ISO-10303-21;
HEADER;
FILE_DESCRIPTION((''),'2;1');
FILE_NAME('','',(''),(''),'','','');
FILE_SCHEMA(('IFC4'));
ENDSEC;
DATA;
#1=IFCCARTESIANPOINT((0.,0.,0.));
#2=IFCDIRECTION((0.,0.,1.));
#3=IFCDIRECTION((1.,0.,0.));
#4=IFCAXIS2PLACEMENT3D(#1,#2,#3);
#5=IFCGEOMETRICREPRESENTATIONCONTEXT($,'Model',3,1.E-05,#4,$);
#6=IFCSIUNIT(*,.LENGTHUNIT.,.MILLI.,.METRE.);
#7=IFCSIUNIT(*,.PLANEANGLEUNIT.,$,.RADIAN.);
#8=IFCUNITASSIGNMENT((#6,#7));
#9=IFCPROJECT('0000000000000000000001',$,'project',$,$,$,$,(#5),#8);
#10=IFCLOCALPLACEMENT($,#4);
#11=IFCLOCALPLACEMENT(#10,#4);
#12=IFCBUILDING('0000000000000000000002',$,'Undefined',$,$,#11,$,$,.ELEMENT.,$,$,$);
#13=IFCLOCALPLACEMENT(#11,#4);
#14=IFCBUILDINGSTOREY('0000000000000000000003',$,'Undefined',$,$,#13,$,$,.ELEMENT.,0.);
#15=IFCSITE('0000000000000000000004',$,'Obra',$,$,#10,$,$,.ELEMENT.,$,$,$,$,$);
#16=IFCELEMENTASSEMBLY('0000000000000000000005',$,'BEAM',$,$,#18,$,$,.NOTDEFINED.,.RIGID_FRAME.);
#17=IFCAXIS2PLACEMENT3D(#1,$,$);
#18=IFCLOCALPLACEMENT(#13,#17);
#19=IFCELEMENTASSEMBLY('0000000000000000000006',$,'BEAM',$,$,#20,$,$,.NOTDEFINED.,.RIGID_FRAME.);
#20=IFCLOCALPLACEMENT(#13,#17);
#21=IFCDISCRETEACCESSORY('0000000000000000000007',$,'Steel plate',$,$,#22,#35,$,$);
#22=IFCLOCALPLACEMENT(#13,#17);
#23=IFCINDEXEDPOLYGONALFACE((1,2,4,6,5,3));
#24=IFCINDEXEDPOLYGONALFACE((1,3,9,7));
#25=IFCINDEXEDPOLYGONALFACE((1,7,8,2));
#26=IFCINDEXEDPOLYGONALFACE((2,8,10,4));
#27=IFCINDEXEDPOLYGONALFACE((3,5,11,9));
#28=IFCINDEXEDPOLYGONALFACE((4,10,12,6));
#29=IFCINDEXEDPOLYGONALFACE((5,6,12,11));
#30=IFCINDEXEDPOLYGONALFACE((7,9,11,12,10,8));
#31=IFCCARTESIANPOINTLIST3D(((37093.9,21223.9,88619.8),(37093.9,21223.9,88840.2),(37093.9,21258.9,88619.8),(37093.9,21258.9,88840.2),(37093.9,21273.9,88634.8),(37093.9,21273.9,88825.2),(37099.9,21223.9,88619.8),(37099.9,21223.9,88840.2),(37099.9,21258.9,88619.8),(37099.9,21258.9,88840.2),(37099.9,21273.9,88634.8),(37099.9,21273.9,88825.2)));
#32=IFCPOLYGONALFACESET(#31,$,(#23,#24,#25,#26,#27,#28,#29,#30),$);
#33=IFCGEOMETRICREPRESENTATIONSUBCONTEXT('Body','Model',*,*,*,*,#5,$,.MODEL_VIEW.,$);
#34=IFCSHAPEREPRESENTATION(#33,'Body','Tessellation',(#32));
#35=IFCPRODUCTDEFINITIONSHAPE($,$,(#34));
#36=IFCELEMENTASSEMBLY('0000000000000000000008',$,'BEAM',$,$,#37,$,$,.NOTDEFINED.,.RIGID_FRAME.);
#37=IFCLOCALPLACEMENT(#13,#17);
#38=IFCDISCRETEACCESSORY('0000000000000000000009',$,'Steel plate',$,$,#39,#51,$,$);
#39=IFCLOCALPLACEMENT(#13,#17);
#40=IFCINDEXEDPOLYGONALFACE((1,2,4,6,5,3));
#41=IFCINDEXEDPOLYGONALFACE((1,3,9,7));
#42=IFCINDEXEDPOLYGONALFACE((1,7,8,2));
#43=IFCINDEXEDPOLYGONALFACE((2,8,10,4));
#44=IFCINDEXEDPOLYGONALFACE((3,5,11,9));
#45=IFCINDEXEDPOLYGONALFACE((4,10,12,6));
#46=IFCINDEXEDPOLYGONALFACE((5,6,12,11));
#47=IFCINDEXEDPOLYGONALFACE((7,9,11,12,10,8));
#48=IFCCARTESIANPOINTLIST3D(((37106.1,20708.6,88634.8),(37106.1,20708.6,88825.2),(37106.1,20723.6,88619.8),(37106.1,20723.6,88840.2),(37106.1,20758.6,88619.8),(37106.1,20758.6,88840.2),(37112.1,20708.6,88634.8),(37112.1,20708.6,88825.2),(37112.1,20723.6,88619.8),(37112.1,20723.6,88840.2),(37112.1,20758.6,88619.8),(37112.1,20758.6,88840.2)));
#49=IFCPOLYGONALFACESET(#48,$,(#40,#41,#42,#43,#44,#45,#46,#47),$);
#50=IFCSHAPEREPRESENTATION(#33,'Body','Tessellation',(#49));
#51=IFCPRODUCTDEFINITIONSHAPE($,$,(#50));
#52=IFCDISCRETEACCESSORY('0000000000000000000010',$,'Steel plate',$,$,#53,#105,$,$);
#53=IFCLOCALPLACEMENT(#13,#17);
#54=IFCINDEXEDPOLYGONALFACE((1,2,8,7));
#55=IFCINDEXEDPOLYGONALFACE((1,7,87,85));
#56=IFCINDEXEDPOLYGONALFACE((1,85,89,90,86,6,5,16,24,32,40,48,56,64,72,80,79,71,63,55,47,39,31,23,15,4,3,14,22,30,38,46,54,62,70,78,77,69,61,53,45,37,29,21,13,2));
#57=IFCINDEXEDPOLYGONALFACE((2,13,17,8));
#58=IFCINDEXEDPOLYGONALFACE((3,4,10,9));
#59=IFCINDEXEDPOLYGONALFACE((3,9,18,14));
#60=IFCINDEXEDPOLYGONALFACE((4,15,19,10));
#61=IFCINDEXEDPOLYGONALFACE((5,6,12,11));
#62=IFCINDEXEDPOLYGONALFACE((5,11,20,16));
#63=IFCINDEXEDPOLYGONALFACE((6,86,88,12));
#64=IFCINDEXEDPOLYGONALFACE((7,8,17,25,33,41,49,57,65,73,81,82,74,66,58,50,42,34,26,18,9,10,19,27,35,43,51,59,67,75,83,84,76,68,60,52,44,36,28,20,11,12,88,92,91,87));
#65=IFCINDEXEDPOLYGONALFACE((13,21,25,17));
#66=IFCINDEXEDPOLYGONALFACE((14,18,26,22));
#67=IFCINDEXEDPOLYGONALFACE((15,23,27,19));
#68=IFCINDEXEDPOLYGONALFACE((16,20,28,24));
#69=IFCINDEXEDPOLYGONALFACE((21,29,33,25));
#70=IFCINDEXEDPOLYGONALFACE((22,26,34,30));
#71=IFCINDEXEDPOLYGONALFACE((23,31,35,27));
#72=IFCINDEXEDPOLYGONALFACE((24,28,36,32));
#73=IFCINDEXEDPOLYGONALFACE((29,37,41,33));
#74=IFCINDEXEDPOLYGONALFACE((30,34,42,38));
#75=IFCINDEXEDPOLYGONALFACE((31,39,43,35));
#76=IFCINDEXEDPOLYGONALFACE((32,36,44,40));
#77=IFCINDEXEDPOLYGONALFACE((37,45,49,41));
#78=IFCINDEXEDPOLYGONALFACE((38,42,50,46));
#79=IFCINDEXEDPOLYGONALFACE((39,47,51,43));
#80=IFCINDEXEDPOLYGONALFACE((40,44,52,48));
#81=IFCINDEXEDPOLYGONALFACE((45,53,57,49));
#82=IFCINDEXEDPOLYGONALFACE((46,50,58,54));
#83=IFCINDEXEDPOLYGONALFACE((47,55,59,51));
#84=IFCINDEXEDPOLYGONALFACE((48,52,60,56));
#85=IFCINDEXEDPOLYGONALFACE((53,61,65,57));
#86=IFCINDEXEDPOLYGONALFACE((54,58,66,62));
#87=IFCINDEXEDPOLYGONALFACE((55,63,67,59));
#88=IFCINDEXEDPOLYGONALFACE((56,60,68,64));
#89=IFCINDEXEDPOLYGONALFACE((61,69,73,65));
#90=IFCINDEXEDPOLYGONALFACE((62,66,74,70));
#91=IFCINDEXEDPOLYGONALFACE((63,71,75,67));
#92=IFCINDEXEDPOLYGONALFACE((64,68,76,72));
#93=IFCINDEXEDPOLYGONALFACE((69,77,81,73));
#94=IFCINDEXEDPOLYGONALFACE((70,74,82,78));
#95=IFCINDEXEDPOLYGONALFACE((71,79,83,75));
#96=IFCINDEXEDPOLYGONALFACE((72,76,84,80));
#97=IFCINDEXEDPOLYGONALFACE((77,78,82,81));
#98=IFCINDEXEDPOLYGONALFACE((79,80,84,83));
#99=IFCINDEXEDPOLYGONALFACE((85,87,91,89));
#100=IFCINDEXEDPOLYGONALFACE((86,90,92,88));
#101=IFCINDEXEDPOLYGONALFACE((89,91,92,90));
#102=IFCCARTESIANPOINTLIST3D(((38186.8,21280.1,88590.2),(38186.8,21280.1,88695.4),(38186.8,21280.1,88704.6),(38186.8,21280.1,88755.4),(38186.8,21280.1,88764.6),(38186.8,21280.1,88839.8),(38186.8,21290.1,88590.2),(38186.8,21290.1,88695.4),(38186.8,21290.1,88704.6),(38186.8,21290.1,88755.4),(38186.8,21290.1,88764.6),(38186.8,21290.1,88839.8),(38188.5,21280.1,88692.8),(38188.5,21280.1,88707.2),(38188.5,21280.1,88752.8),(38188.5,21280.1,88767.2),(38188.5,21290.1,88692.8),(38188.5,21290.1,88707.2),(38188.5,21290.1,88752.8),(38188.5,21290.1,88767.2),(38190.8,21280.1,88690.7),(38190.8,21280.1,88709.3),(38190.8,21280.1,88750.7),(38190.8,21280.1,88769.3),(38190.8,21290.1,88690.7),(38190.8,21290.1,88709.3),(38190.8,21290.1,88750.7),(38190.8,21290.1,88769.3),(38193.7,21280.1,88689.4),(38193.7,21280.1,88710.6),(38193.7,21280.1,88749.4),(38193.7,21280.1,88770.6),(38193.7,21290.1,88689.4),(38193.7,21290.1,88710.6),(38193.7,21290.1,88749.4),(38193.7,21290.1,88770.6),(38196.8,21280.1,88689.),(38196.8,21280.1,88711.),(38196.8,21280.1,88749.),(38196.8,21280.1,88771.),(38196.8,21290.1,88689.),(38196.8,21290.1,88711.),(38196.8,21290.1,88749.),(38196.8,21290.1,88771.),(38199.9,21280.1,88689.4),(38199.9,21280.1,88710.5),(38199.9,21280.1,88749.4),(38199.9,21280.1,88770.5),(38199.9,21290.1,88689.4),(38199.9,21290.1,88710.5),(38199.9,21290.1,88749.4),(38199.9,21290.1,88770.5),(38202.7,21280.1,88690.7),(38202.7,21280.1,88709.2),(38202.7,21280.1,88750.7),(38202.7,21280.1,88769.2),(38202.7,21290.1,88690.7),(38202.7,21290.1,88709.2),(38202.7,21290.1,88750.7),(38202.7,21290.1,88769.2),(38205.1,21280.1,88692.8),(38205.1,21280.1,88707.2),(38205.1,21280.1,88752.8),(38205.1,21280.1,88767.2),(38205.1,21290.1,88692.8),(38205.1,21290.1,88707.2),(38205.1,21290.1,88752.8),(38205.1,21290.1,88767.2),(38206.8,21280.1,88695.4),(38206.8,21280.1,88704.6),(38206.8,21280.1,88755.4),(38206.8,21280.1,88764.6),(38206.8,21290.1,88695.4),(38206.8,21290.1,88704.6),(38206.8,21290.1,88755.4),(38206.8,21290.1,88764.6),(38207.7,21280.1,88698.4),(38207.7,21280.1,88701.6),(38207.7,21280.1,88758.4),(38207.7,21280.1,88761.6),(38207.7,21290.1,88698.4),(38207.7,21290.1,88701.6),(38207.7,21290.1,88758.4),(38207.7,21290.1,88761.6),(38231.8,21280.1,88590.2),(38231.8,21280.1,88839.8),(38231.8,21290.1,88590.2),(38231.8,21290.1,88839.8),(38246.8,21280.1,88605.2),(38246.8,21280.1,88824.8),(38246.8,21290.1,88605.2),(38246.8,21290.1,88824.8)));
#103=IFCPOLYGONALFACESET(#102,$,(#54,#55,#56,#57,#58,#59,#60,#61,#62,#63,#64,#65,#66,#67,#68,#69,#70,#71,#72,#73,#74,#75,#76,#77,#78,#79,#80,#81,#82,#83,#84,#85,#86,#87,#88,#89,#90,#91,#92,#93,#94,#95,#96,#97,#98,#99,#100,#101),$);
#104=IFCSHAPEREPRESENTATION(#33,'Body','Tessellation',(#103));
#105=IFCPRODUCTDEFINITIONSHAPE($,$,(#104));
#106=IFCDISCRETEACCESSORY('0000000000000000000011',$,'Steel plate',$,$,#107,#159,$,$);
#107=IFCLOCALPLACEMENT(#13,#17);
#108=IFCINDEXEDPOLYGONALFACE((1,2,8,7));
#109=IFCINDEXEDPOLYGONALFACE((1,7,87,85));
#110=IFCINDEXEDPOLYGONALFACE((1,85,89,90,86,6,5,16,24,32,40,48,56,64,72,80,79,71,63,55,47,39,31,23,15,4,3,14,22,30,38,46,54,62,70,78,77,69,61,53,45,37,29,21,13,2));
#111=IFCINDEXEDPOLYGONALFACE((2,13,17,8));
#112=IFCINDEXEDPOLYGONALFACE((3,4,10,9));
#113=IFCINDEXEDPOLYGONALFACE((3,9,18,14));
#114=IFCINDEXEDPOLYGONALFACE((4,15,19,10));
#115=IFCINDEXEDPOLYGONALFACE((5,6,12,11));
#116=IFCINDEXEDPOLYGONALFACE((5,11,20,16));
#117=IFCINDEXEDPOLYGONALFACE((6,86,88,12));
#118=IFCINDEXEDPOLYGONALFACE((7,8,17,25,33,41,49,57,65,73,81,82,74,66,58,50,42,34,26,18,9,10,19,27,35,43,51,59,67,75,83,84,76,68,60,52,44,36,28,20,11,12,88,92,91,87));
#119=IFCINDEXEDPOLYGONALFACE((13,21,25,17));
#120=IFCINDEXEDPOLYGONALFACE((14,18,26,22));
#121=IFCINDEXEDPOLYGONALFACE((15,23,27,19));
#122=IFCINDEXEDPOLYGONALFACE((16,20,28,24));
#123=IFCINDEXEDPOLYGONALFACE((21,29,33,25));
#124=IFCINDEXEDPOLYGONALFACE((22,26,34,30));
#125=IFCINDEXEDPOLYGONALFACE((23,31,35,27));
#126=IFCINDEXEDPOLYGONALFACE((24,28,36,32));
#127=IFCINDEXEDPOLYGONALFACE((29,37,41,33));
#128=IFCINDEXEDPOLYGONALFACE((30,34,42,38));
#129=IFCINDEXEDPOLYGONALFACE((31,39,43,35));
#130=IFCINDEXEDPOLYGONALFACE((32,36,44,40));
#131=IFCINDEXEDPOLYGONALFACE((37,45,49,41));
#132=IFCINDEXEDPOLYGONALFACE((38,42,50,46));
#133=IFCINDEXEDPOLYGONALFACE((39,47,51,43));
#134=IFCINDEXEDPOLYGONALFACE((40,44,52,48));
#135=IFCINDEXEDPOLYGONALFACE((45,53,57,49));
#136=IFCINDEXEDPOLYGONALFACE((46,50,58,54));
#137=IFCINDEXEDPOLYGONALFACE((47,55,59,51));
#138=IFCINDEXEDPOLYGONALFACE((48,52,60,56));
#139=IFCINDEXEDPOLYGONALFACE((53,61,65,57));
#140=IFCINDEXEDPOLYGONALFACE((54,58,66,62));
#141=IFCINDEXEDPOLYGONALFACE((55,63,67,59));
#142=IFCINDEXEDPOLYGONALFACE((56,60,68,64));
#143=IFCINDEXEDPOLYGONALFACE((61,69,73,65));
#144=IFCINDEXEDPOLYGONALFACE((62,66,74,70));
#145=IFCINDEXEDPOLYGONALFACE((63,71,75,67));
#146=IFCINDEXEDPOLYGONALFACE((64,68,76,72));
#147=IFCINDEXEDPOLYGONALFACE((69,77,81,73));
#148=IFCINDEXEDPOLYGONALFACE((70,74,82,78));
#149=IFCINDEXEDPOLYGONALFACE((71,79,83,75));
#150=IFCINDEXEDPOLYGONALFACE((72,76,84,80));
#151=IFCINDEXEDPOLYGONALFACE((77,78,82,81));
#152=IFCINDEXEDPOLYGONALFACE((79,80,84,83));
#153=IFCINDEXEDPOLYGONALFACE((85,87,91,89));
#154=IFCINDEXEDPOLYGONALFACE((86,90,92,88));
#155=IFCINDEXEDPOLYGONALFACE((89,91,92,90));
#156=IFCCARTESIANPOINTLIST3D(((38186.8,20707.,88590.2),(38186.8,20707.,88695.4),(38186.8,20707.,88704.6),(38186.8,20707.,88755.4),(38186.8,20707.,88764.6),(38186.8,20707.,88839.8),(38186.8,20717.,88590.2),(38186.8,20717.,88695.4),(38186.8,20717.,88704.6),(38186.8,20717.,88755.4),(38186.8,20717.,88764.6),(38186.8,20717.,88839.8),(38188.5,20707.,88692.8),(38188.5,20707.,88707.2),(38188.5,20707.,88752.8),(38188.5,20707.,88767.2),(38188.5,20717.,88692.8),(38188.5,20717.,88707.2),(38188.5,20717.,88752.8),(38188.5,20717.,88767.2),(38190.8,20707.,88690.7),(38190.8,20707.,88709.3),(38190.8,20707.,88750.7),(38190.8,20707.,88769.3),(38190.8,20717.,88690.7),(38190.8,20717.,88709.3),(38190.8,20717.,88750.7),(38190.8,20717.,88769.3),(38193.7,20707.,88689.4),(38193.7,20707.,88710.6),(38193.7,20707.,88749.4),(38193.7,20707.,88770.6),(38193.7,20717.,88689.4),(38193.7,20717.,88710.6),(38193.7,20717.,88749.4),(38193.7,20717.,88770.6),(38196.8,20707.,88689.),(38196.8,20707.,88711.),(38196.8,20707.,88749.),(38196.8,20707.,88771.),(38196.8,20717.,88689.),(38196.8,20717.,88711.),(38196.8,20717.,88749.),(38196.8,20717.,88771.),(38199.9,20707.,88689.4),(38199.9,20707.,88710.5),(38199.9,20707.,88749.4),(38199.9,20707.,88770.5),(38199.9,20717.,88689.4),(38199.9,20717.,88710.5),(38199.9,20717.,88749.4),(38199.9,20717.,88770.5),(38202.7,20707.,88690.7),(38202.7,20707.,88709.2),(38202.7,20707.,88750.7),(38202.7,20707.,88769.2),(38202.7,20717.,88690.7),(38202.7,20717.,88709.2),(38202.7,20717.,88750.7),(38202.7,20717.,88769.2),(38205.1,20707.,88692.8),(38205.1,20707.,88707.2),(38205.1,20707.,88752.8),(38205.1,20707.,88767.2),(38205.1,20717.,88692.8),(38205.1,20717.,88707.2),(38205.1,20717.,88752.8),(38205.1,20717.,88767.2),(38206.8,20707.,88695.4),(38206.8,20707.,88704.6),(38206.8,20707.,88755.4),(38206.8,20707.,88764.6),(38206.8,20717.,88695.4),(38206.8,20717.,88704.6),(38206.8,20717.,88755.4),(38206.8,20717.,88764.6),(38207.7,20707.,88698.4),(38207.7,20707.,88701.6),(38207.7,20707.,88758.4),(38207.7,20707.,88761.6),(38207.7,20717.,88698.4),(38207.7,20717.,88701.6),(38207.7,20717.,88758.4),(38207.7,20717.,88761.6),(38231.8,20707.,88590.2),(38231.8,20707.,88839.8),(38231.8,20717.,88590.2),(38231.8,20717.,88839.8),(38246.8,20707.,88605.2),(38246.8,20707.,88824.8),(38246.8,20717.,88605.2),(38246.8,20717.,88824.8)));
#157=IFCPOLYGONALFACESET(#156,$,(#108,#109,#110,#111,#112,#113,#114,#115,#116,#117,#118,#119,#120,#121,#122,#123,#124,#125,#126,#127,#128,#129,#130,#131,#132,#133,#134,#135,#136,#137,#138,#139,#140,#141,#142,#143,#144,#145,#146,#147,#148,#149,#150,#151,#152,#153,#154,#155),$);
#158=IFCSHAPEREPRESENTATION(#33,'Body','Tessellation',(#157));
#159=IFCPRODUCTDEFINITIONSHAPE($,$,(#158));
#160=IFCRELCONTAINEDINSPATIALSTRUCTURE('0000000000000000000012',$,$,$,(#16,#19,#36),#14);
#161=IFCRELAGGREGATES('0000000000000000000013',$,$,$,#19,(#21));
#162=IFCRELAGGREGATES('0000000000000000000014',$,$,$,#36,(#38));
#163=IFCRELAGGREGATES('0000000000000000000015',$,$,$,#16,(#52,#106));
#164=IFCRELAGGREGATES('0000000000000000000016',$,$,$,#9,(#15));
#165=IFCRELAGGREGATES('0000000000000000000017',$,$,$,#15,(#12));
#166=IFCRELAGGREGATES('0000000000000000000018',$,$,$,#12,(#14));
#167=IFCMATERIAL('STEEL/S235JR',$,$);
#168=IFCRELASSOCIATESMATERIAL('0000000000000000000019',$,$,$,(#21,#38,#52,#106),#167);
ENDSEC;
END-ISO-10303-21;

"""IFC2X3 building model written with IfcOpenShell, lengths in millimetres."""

from ifc_helpers import new_model, si_unit, frame, origin_with_axes, origin_2d_with_axis, place, context, subcontext, project, spatial, polyline, circle, outline, extrude, source, transform, mapped, material, element, aggregate, save


model = new_model("IFC2X3")

# Units and contexts
model_context = context("Model", 3, precision=1e-05, world=origin_with_axes())
body_context = subcontext(model_context, "Body", "Model", "MODEL_VIEW")
ifc_project = project(units=[si_unit("LENGTHUNIT", "METRE", prefix="MILLI"), si_unit("PLANEANGLEUNIT", "RADIAN")], contexts=[model_context])

# Site, building, storey
site_placement = place(None, origin_with_axes())
site = spatial("IfcSite", under=ifc_project, at=site_placement, Name="Obra", CompositionType="ELEMENT")
building_placement = place(site_placement, origin_with_axes())
building = spatial("IfcBuilding", under=site, at=building_placement, Name="Undefined", CompositionType="ELEMENT")
storey_placement = place(building_placement, origin_with_axes())
storey = spatial("IfcBuildingStorey", under=building, at=storey_placement, Name="Undefined", CompositionType="ELEMENT", Elevation=0.0)

# Element assembly
ifc_material = material(Name="STEEL/S235JR")
assembly_1_placement = place(storey_placement, origin_with_axes())
assembly_1 = element("IfcElementAssembly", 1, at=assembly_1_placement, inside=storey, Name="BEAM", AssemblyPlace="NOTDEFINED", PredefinedType="RIGID_FRAME")

# Element assemblies, discrete accessories
assembly_2_placement = place(storey_placement, origin_with_axes())
assembly_2 = element("IfcElementAssembly", 2, at=assembly_2_placement, inside=storey, Name="BEAM", AssemblyPlace="NOTDEFINED", PredefinedType="RIGID_FRAME")
discrete_accessory_1_placement = place(assembly_2_placement, frame((37096.9, 21223.9, 88619.8), z_axis=(1.0, 0.0, 0.0), x_axis=(0.0, 1.0, 0.0)))
discrete_accessory_1 = element("IfcDiscreteAccessory", 3, at=discrete_accessory_1_placement, material=ifc_material, Name="Steel plate", context=body_context, shape_type="SweptSolid", body=[
    extrude(outline(polyline([(0.0, 0.0), (35.0, 0.0), (50.0, 15.0), (50.0, 205.4), (35.0, 220.4), (0.0, 220.4), (0.0, 0.0)])), frame((0.0, 0.0, -3.0), z_axis=(0.0, 0.0, 1.0), x_axis=(1.0, 0.0, 0.0)), (0.0, 0.0, 1.0), 6.0),
])
aggregate(assembly_2, [discrete_accessory_1])
assembly_3_placement = place(storey_placement, origin_with_axes())
assembly_3 = element("IfcElementAssembly", 4, at=assembly_3_placement, inside=storey, Name="BEAM", AssemblyPlace="NOTDEFINED", PredefinedType="RIGID_FRAME")
discrete_accessory_2_placement = place(assembly_3_placement, frame((37109.1, 20758.6, 88619.8), z_axis=(-0.999999, 0.001435, 0.0), x_axis=(-0.001435, -0.999999, 0.0)))
discrete_accessory_2 = element("IfcDiscreteAccessory", 5, at=discrete_accessory_2_placement, material=ifc_material, Name="Steel plate", context=body_context, shape_type="SweptSolid", body=[
    extrude(outline(polyline([(0.0, 0.0), (35.0, 0.0), (50.0, 15.0), (50.0, 205.4), (35.0, 220.4), (0.0, 220.4), (0.0, 0.0)])), frame((0.0, 0.0, -3.0), z_axis=(0.0, 0.0, 1.0), x_axis=(1.0, 0.0, 0.0)), (0.0, 0.0, 1.0), 6.0),
])
aggregate(assembly_3, [discrete_accessory_2])

# Discrete accessories, openings
discrete_accessory_3_placement = place(assembly_1_placement, frame((38186.8, 21285.1, 88590.2), z_axis=(0.0, -1.0, 0.0), x_axis=(1.0, 0.0, 0.0)))
discrete_accessory_3 = element("IfcDiscreteAccessory", 6, at=discrete_accessory_3_placement, material=ifc_material, Name="Steel plate", context=body_context, shape_type="SweptSolid", body=[
    extrude(outline(polyline([(0.0, 0.0), (45.0, 0.0), (60.0, 15.0), (60.0, 234.6), (45.0, 249.6), (0.0, 249.6), (0.0, 0.0)])), frame((0.0, 0.0, -5.0), z_axis=(0.0, 0.0, 1.0), x_axis=(1.0, 0.0, 0.0)), (0.0, 0.0, 1.0), 10.0),
])
shared_shape_1 = source(origin_with_axes(), body_context, "Body", "SweptSolid", [
    extrude(circle(Radius=11.0, at=origin_2d_with_axis()), frame((0.0, -13.2, 0.0), z_axis=(0.0, 1.0, 0.0), x_axis=(1.0, 0.0, 0.0)), (0.0, 0.0, 1.0), 10.2),
])
opening_1_placement = place(assembly_1_placement, frame((38236.8, 21277.0, 88850.0), z_axis=(-1.0, 0.0, 0.0), x_axis=(0.0, 0.0, -1.0)))
element("IfcOpeningElement", 7, at=opening_1_placement, cuts=discrete_accessory_3, ObjectType="Opening", context=body_context, shape_type="MappedRepresentation", body=[
    mapped(shared_shape_1, transform((90.0, 0.0, 40.0))),
    mapped(shared_shape_1, transform((150.0, 0.0, 40.0))),
])
discrete_accessory_4_placement = place(assembly_1_placement, frame((38186.8, 20712.0, 88590.2), z_axis=(0.0, -1.0, 0.0), x_axis=(1.0, 0.0, 0.0)))
discrete_accessory_4 = element("IfcDiscreteAccessory", 8, at=discrete_accessory_4_placement, material=ifc_material, Name="Steel plate", context=body_context, shape_type="SweptSolid", body=[
    extrude(outline(polyline([(0.0, 0.0), (45.0, 0.0), (60.0, 15.0), (60.0, 234.6), (45.0, 249.6), (0.0, 249.6), (0.0, 0.0)])), frame((0.0, 0.0, -5.0), z_axis=(0.0, 0.0, 1.0), x_axis=(1.0, 0.0, 0.0)), (0.0, 0.0, 1.0), 10.0),
])
opening_2_placement = place(assembly_1_placement, frame((38236.8, 20703.9, 88850.0), z_axis=(-1.0, 0.0, 0.0), x_axis=(0.0, 0.0, -1.0)))
element("IfcOpeningElement", 9, at=opening_2_placement, cuts=discrete_accessory_4, ObjectType="Opening", context=body_context, shape_type="MappedRepresentation", body=[
    mapped(shared_shape_1, transform((90.0, 0.0, 40.0))),
    mapped(shared_shape_1, transform((150.0, 0.0, 40.0))),
])
aggregate(assembly_1, [discrete_accessory_3, discrete_accessory_4])

save(model, "model.ifc")
